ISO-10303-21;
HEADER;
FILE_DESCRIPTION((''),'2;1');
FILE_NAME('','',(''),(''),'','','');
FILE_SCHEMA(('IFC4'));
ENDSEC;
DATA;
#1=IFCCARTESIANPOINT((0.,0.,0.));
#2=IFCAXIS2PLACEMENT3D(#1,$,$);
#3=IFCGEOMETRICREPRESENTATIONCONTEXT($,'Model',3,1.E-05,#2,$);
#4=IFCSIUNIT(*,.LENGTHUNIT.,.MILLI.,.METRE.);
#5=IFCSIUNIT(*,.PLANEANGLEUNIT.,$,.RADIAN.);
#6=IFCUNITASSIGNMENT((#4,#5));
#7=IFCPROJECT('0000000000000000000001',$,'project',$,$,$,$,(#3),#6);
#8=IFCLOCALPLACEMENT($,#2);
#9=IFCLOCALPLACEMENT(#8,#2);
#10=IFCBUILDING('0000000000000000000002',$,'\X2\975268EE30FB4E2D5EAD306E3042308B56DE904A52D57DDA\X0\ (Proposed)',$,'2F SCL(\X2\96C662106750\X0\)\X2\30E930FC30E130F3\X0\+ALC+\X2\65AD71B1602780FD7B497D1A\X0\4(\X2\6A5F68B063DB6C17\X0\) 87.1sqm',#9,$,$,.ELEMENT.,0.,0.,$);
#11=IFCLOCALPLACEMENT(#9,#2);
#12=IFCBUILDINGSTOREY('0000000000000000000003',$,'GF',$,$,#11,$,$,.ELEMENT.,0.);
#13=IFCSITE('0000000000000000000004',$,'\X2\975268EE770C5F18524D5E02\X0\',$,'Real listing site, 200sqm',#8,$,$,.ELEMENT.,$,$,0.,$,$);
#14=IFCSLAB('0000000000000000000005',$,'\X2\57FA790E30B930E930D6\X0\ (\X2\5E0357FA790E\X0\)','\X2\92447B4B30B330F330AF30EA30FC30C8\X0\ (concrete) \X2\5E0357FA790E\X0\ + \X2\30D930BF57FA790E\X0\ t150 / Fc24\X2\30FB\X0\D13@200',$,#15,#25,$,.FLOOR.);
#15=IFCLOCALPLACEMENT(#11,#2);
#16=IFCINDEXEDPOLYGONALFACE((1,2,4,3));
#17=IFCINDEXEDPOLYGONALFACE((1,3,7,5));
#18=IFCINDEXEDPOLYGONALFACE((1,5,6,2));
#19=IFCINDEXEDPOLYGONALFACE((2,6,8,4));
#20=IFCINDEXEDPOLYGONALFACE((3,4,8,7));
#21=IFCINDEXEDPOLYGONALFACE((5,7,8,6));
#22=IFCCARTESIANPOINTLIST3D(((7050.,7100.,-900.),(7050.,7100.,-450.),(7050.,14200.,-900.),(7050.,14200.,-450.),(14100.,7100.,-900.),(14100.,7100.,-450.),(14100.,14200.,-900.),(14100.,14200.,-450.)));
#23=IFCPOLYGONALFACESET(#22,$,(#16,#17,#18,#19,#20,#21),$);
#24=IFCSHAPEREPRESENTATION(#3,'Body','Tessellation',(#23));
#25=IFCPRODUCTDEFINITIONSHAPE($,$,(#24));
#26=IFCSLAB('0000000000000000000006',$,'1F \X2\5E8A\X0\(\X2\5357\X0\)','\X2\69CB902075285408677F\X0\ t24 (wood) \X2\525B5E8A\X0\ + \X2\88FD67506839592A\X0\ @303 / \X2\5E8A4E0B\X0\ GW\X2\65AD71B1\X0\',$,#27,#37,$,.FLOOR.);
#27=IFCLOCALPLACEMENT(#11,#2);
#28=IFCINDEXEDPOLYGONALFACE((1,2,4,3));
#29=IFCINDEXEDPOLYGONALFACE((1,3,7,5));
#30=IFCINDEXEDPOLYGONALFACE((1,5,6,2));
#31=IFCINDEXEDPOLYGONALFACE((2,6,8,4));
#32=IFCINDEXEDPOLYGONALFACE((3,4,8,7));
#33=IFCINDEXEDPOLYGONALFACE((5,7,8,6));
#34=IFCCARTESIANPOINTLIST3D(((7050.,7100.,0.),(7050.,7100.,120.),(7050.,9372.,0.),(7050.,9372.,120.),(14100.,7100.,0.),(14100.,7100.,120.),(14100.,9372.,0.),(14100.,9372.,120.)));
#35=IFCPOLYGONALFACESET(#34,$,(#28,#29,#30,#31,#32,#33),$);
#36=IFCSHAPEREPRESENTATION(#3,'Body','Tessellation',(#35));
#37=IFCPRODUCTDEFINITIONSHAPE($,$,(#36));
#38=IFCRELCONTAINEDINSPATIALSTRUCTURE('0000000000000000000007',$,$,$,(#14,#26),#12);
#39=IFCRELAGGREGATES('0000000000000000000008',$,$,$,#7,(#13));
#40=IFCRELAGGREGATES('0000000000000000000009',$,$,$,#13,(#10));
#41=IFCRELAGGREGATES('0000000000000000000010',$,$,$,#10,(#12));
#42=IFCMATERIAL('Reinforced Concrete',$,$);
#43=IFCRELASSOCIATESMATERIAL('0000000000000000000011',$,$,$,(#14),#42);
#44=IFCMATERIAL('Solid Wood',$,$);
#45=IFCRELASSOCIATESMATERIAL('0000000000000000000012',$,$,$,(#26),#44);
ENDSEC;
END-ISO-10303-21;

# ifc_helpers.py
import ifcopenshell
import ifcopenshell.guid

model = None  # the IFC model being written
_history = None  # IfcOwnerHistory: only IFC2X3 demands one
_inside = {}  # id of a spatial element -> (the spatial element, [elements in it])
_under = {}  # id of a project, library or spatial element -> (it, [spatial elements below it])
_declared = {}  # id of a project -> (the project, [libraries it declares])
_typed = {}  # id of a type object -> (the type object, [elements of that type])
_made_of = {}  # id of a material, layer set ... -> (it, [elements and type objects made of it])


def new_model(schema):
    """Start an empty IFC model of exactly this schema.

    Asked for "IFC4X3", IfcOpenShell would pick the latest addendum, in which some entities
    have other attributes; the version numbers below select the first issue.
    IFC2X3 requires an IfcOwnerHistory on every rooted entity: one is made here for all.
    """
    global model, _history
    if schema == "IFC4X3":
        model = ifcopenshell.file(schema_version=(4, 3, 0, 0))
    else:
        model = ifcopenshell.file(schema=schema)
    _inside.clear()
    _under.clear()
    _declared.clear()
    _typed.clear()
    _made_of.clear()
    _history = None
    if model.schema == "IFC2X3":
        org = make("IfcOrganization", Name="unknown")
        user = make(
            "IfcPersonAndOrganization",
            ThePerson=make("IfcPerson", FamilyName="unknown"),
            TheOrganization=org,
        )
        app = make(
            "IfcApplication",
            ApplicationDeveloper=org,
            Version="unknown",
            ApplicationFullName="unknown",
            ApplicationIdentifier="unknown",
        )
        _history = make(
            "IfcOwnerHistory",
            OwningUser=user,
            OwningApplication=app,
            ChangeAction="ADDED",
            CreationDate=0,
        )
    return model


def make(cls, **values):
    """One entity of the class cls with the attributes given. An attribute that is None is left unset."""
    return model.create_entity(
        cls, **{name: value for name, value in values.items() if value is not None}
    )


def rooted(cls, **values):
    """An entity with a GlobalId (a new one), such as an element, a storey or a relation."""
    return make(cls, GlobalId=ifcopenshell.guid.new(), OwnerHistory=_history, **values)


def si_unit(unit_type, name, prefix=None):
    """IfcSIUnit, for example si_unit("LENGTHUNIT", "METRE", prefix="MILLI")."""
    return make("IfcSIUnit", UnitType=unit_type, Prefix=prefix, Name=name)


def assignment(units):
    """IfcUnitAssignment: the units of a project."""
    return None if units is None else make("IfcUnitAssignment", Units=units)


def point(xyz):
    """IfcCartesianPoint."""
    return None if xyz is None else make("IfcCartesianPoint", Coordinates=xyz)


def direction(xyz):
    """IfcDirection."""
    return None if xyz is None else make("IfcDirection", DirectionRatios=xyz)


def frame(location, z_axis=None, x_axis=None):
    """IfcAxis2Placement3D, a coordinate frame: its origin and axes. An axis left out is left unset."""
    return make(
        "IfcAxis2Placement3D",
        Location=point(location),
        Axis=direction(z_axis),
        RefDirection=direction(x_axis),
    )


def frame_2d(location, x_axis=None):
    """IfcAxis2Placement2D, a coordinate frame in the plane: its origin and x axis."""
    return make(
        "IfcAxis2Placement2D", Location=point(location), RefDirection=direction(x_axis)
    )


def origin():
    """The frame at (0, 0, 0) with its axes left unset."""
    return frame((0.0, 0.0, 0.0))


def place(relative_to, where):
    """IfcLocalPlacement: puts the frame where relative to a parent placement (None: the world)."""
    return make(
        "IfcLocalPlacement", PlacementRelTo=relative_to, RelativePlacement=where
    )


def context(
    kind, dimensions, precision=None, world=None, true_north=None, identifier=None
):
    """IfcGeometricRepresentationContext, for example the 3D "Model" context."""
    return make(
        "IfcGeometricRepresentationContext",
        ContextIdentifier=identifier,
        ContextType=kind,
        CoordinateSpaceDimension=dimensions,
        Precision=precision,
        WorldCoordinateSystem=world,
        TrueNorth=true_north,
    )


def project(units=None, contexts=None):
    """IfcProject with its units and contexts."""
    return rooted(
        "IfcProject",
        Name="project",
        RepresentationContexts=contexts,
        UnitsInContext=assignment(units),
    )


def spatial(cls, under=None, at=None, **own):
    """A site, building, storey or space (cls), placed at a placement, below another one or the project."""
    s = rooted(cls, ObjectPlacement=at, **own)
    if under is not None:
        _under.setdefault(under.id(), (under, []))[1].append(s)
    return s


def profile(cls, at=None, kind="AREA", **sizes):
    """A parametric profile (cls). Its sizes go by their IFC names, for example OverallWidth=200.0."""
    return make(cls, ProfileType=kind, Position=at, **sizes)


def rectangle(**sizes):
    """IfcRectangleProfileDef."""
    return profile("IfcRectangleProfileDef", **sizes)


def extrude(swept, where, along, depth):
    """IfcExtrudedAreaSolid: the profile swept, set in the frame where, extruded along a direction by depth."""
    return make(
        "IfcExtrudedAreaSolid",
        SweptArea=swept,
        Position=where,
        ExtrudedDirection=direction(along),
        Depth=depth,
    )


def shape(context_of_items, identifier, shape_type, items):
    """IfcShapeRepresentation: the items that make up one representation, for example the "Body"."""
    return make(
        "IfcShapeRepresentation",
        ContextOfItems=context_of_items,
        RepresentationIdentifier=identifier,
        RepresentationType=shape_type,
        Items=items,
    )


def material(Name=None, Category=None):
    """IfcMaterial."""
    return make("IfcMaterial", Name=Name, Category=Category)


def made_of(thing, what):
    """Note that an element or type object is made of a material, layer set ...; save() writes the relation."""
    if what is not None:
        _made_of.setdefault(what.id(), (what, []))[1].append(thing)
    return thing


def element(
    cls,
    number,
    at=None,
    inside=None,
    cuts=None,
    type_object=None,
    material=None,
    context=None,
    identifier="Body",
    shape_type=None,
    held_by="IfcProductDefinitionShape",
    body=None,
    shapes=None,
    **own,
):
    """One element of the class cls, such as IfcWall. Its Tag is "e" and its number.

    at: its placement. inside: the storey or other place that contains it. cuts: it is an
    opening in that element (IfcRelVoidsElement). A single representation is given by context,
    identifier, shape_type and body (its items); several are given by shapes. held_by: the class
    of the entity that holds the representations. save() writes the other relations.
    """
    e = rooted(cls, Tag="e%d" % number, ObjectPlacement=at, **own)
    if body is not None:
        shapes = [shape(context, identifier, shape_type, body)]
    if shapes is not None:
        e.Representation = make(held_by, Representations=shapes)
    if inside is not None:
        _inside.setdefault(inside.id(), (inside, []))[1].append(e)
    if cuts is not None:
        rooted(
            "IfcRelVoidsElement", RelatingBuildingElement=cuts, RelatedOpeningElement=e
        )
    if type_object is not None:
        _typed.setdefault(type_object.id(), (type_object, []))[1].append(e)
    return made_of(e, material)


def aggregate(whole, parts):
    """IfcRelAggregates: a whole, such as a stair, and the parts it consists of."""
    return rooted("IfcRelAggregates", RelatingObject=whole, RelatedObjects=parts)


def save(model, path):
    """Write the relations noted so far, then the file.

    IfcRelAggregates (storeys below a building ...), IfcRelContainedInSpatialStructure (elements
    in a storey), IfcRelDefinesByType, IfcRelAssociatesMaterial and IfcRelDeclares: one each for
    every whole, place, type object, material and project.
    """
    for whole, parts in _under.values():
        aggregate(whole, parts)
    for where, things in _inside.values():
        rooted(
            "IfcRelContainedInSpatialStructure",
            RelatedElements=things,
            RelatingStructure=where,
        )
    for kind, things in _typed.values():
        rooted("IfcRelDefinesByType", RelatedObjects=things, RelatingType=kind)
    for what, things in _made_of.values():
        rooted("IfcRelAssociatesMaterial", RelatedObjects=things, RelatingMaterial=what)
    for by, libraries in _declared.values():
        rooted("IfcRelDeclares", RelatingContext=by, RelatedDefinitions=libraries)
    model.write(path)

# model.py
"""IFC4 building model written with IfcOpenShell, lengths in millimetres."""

from ifc_helpers import new_model, si_unit, frame, frame_2d, origin, place, context, project, spatial, rectangle, extrude, material, element, save


model = new_model("IFC4")

# Units and contexts
model_context = context("Model", 3, precision=1e-05, world=origin())
ifc_project = project(units=[si_unit("LENGTHUNIT", "METRE", prefix="MILLI"), si_unit("PLANEANGLEUNIT", "RADIAN")], contexts=[model_context])

# Site, building, storey
site_placement = place(None, origin())
site = spatial("IfcSite", under=ifc_project, at=site_placement, Name="青森県弘前市", ObjectType="Real listing site, 200sqm", CompositionType="ELEMENT", RefElevation=0.0)
building_placement = place(site_placement, origin())
building = spatial("IfcBuilding", under=site, at=building_placement, Name="青森・中庭のある回遊動線 (Proposed)", ObjectType="2F SCL(集成材)ラーメン+ALC+断熱性能等級4(機械換気) 87.1sqm", CompositionType="ELEMENT", ElevationOfRefHeight=0.0, ElevationOfTerrain=0.0)
storey_placement = place(building_placement, origin())
storey = spatial("IfcBuildingStorey", under=building, at=storey_placement, Name="GF", CompositionType="ELEMENT", Elevation=0.0)

# Shared definitions
ifc_material_1 = material(Name="Solid Wood")

# Slabs
ifc_material_2 = material(Name="Reinforced Concrete")
slab_1_placement = place(storey_placement, frame((3525.0, 3550.0, -450.0)))
element("IfcSlab", 1, at=slab_1_placement, inside=storey, material=ifc_material_2, Name="基礎スラブ (布基礎)", Description="鉄筋コンクリート (concrete) 布基礎 + ベタ基礎 t150 / Fc24・D13@200", PredefinedType="FLOOR", context=model_context, shape_type="SweptSolid", body=[
    extrude(rectangle(XDim=7050.0, YDim=7100.0, at=frame_2d((3525.0, 3550.0))), frame((3525.0, 3550.0, -450.0)), (0.0, 0.0, 1.0), 450.0),
])
slab_2_placement = place(storey_placement, frame((3525.0, 3550.0, 0.0)))
element("IfcSlab", 2, at=slab_2_placement, inside=storey, material=ifc_material_1, Name="1F 床(南)", Description="構造用合板 t24 (wood) 剛床 + 製材根太 @303 / 床下 GW断熱", PredefinedType="FLOOR", context=model_context, shape_type="SweptSolid", body=[
    extrude(rectangle(XDim=7050.0, YDim=2272.0, at=frame_2d((3525.0, 1136.0))), frame((3525.0, 3550.0, 0.0)), (0.0, 0.0, 1.0), 120.0),
])

save(model, "model.ifc")
